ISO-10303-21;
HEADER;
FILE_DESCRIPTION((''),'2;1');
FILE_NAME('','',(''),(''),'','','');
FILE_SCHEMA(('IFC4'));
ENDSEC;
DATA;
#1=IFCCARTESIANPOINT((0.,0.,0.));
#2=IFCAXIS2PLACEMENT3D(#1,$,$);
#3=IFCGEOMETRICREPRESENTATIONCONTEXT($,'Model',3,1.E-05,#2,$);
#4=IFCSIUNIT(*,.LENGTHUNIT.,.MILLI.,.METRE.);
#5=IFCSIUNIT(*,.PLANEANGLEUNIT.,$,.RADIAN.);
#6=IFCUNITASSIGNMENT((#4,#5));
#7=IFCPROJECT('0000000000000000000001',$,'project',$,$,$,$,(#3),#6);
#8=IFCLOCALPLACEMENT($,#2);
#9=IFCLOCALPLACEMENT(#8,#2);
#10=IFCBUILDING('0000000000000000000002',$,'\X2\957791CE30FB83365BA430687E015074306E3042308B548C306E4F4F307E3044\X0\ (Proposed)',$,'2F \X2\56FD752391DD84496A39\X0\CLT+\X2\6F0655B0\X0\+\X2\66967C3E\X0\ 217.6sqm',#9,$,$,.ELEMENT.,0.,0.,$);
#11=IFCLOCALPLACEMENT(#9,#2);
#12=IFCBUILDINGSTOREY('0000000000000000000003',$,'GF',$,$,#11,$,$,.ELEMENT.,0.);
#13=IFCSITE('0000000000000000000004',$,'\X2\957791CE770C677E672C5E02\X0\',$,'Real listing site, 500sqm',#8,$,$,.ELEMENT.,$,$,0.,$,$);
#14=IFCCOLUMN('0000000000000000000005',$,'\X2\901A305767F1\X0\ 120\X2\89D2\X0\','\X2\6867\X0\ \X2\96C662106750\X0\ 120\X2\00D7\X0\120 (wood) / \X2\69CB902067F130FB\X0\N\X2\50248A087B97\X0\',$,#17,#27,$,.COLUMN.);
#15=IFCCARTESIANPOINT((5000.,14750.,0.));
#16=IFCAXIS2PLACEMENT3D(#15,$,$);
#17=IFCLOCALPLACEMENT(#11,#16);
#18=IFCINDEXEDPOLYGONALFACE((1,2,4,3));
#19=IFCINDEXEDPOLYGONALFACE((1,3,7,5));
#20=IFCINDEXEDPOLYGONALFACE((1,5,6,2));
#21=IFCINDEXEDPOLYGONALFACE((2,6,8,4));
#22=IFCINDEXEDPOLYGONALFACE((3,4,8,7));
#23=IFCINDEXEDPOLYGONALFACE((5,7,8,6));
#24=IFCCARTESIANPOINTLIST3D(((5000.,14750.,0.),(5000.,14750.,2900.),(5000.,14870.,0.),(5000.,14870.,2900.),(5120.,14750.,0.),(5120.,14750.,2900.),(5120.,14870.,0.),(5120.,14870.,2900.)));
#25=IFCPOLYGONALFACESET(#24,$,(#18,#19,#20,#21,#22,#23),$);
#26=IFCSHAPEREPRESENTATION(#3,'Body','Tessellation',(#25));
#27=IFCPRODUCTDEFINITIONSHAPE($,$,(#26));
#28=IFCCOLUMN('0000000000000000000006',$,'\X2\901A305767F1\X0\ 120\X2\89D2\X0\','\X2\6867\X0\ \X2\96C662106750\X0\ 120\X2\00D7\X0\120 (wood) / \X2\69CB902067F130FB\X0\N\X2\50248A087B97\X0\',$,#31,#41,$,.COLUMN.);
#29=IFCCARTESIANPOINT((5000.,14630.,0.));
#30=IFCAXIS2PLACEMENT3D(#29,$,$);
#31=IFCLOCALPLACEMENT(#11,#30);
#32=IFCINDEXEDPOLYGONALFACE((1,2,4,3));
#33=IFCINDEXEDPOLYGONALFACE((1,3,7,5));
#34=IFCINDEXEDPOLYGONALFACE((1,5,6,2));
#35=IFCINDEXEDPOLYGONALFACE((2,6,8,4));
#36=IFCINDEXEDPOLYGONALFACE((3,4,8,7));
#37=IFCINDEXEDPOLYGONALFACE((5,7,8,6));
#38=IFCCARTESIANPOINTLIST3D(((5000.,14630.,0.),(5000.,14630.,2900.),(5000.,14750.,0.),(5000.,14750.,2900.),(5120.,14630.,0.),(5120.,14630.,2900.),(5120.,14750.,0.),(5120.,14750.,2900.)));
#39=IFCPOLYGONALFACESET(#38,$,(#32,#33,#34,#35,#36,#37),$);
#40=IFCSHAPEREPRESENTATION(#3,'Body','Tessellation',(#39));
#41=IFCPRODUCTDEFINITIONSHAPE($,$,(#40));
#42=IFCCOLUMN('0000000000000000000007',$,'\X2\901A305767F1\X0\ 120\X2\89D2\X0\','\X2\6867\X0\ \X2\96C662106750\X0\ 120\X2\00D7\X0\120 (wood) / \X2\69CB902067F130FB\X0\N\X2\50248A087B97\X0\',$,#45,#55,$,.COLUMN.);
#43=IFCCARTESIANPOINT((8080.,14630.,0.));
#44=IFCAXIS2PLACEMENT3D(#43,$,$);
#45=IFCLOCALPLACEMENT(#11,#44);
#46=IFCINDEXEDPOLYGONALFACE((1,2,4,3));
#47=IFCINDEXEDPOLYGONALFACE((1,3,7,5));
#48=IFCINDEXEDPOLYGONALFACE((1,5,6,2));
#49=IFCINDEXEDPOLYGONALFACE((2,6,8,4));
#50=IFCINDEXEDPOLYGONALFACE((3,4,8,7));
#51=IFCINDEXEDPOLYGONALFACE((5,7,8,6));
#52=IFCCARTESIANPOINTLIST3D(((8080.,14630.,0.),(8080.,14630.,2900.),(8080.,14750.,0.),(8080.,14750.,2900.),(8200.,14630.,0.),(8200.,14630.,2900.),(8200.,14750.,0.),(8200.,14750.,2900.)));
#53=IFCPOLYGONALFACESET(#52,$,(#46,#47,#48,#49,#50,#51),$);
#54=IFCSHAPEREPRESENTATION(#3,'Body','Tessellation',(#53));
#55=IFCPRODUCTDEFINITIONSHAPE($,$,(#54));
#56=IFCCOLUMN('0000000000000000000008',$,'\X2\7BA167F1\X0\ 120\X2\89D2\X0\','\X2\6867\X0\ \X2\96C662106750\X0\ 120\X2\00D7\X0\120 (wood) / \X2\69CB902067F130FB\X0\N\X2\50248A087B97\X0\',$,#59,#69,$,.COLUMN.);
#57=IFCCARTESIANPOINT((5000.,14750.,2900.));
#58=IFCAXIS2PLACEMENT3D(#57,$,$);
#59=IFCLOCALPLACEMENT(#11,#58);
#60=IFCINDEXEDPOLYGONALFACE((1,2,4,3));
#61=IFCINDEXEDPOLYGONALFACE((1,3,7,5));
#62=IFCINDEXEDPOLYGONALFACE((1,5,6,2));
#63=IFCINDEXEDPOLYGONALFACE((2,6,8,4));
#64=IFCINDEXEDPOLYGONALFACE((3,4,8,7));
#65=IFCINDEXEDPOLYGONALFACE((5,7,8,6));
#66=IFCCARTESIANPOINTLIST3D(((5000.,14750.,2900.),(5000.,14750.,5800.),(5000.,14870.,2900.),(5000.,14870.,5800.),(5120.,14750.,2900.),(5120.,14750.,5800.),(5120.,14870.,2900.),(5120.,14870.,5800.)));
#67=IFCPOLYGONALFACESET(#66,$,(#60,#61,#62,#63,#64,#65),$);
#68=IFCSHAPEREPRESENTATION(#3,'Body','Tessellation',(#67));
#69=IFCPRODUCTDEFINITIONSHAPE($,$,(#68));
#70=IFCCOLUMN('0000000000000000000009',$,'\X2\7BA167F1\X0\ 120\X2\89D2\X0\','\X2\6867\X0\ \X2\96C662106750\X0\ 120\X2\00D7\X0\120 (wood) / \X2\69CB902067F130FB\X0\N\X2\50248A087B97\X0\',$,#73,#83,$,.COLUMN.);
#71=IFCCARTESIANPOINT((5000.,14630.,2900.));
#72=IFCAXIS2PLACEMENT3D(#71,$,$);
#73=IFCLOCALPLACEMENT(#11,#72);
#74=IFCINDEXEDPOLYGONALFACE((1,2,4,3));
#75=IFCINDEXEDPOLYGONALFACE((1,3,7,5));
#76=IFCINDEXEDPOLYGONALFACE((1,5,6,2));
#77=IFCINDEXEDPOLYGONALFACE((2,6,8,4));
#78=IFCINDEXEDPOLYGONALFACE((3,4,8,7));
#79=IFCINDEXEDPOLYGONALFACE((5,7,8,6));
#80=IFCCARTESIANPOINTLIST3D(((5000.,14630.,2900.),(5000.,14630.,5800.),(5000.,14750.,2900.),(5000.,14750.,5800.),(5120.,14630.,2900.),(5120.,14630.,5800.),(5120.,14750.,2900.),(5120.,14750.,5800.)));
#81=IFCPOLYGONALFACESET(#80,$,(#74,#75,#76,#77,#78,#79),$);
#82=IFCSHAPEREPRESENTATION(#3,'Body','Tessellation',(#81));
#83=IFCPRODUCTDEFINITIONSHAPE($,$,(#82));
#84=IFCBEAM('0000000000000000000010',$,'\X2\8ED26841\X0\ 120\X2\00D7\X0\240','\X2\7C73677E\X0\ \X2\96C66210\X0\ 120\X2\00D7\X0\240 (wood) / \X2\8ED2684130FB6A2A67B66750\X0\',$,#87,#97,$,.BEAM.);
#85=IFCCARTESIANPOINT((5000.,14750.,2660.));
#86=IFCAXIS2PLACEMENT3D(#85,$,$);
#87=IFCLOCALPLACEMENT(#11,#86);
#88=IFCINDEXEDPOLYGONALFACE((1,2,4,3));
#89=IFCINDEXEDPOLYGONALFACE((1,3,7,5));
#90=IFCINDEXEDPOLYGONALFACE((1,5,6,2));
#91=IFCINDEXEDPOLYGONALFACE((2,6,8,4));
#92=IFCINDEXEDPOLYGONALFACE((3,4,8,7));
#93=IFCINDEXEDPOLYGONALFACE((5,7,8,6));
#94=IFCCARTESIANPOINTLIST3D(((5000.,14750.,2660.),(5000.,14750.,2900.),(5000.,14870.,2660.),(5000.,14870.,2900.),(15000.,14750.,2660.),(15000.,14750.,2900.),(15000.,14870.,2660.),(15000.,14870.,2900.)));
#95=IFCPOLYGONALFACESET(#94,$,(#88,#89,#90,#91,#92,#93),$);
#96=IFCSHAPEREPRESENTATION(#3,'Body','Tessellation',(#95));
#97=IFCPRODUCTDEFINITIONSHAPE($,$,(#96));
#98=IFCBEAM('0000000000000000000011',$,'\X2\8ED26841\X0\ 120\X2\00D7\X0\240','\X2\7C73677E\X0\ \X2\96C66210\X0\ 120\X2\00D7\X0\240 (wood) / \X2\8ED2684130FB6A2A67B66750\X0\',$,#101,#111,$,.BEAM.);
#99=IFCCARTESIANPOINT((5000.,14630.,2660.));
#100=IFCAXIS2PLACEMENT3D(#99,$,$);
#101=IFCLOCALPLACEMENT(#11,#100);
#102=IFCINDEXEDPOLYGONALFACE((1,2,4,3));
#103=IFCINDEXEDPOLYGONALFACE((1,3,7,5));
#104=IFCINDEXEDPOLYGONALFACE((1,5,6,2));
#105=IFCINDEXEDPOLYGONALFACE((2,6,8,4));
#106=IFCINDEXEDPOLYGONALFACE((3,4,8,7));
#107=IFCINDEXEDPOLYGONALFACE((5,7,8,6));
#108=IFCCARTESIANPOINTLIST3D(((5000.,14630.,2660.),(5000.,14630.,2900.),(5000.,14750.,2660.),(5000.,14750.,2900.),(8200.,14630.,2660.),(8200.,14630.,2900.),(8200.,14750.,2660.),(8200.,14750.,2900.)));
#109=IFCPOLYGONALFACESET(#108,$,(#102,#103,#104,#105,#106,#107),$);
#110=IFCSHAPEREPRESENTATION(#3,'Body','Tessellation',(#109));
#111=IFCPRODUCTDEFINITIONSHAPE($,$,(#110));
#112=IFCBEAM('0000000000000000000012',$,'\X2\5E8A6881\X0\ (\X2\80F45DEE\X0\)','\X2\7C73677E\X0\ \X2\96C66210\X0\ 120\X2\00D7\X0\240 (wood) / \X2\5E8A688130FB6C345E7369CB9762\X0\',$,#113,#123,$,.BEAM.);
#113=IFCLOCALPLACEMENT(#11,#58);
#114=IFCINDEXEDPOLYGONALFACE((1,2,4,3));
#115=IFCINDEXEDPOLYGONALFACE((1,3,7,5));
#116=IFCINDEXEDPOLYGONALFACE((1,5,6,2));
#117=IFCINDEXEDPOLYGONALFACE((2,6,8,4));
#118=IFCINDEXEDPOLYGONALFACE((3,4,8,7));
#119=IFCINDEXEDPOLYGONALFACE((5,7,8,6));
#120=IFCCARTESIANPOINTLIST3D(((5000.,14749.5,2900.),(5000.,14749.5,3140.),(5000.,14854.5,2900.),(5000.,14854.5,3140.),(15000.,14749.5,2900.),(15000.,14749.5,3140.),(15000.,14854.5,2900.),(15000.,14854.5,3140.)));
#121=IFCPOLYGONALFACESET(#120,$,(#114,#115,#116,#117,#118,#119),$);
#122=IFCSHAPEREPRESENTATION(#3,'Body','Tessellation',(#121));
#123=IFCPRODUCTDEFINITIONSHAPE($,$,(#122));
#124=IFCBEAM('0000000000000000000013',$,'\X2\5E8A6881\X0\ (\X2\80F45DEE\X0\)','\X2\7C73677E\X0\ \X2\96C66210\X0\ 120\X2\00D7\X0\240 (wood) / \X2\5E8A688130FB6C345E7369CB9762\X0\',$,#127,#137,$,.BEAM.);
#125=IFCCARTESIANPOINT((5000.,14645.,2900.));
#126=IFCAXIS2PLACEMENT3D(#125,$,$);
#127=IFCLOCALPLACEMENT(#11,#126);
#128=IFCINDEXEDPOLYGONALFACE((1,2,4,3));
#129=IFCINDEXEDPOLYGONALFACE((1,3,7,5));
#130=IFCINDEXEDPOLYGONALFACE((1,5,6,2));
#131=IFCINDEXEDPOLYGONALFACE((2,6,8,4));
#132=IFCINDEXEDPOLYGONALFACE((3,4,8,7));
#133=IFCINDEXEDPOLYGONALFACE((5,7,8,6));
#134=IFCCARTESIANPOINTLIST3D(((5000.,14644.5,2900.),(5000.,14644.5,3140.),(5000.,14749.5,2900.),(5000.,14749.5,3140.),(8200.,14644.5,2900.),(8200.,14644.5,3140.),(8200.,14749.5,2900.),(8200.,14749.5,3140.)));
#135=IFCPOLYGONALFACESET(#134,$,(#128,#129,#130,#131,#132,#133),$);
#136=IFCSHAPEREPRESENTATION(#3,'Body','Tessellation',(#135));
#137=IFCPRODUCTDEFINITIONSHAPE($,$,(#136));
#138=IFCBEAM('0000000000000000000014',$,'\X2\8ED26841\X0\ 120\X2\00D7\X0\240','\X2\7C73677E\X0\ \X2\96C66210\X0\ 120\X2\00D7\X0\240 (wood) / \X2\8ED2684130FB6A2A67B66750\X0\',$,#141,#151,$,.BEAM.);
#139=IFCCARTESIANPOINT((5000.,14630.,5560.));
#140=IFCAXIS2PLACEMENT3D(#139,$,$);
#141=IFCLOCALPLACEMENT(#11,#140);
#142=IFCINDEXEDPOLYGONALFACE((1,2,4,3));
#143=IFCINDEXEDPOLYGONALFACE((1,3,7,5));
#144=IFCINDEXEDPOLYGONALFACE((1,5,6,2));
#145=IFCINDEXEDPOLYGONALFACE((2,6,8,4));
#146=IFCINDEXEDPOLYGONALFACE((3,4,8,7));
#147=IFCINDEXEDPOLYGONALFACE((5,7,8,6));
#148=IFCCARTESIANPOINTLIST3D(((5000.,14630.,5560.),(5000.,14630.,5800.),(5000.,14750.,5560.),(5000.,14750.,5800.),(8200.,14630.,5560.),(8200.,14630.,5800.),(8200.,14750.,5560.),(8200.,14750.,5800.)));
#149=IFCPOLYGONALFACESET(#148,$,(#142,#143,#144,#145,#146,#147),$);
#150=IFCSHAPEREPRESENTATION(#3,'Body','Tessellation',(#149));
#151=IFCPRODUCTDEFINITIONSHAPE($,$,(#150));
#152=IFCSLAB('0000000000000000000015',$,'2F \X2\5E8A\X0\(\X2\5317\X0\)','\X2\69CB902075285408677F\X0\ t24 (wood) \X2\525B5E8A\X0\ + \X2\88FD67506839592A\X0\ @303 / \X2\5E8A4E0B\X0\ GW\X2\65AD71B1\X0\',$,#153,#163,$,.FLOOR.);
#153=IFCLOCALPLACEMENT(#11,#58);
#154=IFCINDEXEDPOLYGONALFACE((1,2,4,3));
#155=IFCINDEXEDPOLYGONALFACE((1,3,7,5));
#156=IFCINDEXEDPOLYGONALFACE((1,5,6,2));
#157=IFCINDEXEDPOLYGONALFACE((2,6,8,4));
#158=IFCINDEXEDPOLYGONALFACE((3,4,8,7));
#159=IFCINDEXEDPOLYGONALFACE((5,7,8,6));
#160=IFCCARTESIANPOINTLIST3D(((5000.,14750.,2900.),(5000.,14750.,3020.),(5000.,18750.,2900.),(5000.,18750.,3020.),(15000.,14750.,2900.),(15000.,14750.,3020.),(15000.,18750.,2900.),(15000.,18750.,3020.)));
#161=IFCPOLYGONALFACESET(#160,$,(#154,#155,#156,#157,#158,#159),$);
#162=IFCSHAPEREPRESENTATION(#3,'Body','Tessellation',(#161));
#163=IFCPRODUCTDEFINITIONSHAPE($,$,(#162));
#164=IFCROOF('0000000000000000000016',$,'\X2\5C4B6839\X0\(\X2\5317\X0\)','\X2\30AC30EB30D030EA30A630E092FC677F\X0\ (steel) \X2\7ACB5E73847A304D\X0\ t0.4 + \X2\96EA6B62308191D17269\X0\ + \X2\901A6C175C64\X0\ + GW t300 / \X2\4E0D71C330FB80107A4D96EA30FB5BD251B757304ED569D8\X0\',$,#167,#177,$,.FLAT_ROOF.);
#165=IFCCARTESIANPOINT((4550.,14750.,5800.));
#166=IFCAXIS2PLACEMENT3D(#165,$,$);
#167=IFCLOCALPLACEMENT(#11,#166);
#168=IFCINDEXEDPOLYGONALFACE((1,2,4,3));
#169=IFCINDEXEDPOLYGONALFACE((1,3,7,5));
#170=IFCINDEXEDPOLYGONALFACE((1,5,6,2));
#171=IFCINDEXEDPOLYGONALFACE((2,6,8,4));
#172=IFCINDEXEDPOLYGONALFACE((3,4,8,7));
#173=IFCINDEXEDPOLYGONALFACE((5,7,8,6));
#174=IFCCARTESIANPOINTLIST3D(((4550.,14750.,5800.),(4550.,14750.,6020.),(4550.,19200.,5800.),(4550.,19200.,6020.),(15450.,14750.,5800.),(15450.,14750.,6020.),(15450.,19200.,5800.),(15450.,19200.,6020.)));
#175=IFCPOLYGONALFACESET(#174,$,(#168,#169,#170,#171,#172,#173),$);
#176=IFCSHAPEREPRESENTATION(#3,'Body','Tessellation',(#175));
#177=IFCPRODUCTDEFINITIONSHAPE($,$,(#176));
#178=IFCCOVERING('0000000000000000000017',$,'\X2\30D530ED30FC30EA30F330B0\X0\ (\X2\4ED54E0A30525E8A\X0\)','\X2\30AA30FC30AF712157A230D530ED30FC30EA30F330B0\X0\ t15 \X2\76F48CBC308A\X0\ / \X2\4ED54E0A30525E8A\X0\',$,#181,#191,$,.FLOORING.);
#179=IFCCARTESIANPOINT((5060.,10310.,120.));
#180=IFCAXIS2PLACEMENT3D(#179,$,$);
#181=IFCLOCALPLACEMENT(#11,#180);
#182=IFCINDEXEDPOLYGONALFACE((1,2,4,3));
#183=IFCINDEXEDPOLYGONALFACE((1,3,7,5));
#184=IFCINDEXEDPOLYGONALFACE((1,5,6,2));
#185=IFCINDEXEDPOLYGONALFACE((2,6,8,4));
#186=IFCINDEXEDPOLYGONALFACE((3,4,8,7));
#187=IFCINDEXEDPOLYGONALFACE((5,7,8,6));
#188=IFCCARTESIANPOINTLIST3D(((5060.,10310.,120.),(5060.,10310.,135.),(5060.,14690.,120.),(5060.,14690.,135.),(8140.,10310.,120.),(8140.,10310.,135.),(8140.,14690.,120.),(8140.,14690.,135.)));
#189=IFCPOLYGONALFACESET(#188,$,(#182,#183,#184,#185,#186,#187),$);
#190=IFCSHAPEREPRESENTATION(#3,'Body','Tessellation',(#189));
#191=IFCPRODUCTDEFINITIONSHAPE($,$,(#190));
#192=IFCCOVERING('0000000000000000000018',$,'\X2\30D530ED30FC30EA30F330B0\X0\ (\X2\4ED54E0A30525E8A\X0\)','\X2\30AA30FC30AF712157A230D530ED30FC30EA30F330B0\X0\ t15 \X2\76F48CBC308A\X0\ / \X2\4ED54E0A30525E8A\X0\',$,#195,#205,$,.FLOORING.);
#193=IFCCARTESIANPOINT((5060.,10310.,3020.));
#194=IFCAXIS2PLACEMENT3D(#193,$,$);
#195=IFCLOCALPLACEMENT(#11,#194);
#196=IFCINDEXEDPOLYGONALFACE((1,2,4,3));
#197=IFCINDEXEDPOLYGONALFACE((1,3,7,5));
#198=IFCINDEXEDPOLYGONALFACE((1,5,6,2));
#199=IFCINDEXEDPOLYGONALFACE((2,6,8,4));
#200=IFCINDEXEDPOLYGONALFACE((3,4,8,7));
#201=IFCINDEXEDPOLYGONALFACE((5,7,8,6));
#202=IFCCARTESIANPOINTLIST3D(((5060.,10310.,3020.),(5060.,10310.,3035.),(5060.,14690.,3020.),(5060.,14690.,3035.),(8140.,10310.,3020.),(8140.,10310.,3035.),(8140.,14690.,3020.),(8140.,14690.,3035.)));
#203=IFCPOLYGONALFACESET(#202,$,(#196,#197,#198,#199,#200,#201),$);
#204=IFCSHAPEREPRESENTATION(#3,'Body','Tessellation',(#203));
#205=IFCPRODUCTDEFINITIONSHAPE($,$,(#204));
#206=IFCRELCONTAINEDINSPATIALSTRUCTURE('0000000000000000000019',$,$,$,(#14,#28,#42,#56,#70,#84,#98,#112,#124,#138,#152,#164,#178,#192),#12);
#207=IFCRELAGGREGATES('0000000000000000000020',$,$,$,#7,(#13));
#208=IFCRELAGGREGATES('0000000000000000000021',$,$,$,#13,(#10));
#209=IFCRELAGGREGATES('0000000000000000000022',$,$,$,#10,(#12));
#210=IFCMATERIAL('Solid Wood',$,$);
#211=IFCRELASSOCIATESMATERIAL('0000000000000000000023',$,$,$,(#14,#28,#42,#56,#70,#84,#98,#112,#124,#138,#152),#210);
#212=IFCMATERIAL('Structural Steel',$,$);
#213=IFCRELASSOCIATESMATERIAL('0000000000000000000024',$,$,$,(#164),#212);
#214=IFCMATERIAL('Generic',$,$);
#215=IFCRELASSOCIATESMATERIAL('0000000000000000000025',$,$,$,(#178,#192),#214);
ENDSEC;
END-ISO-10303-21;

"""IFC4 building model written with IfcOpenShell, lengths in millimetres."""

from ifc_helpers import new_model, si_unit, frame, frame_2d, origin, place, context, project, spatial, rectangle, extrude, material, element, save


model = new_model("IFC4")

# Units and contexts
model_context = context("Model", 3, precision=1e-05, world=origin())
ifc_project = project(units=[si_unit("LENGTHUNIT", "METRE", prefix="MILLI"), si_unit("PLANEANGLEUNIT", "RADIAN")], contexts=[model_context])

# Site, building, storey
site_placement = place(None, origin())
site = spatial("IfcSite", under=ifc_project, at=site_placement, Name="長野県松本市", ObjectType="Real listing site, 500sqm", CompositionType="ELEMENT", RefElevation=0.0)
building_placement = place(site_placement, origin())
building = spatial("IfcBuilding", under=site, at=building_placement, Name="長野・茶室と縁側のある和の住まい (Proposed)", ObjectType="2F 国産針葉樹CLT+漆喰+暖簾 217.6sqm", CompositionType="ELEMENT", ElevationOfRefHeight=0.0, ElevationOfTerrain=0.0)
storey_placement = place(building_placement, origin())
storey = spatial("IfcBuildingStorey", under=building, at=storey_placement, Name="GF", CompositionType="ELEMENT", Elevation=0.0)

# Columns
ifc_material_1 = material(Name="Solid Wood")
column_1_placement = place(storey_placement, frame((5000.0, 14750.0, 0.0)))
element("IfcColumn", 1, at=column_1_placement, inside=storey, material=ifc_material_1, Name="通し柱 120角", Description="桧 集成材 120×120 (wood) / 構造柱・N値計算", PredefinedType="COLUMN", context=model_context, shape_type="SweptSolid", body=[
    extrude(rectangle(XDim=120.0, YDim=120.0, at=frame_2d((60.0, 60.0))), frame((5000.0, 14750.0, 0.0)), (0.0, 0.0, 1.0), 2900.0),
])
column_2_placement = place(storey_placement, frame((5000.0, 14630.0, 0.0)))
element("IfcColumn", 2, at=column_2_placement, inside=storey, material=ifc_material_1, Name="通し柱 120角", Description="桧 集成材 120×120 (wood) / 構造柱・N値計算", PredefinedType="COLUMN", context=model_context, shape_type="SweptSolid", body=[
    extrude(rectangle(XDim=120.0, YDim=120.0, at=frame_2d((60.0, 60.0))), frame((5000.0, 14630.0, 0.0)), (0.0, 0.0, 1.0), 2900.0),
])
column_3_placement = place(storey_placement, frame((8080.0, 14630.0, 0.0)))
element("IfcColumn", 3, at=column_3_placement, inside=storey, material=ifc_material_1, Name="通し柱 120角", Description="桧 集成材 120×120 (wood) / 構造柱・N値計算", PredefinedType="COLUMN", context=model_context, shape_type="SweptSolid", body=[
    extrude(rectangle(XDim=120.0, YDim=120.0, at=frame_2d((60.0, 60.0))), frame((8080.0, 14630.0, 0.0)), (0.0, 0.0, 1.0), 2900.0),
])
column_4_placement = place(storey_placement, frame((5000.0, 14750.0, 2900.0)))
element("IfcColumn", 4, at=column_4_placement, inside=storey, material=ifc_material_1, Name="管柱 120角", Description="桧 集成材 120×120 (wood) / 構造柱・N値計算", PredefinedType="COLUMN", context=model_context, shape_type="SweptSolid", body=[
    extrude(rectangle(XDim=120.0, YDim=120.0, at=frame_2d((60.0, 60.0))), frame((5000.0, 14750.0, 2900.0)), (0.0, 0.0, 1.0), 2900.0),
])
column_5_placement = place(storey_placement, frame((5000.0, 14630.0, 2900.0)))
element("IfcColumn", 5, at=column_5_placement, inside=storey, material=ifc_material_1, Name="管柱 120角", Description="桧 集成材 120×120 (wood) / 構造柱・N値計算", PredefinedType="COLUMN", context=model_context, shape_type="SweptSolid", body=[
    extrude(rectangle(XDim=120.0, YDim=120.0, at=frame_2d((60.0, 60.0))), frame((5000.0, 14630.0, 2900.0)), (0.0, 0.0, 1.0), 2900.0),
])

# Beams
beam_1_placement = place(storey_placement, frame((5000.0, 14750.0, 2660.0)))
element("IfcBeam", 6, at=beam_1_placement, inside=storey, material=ifc_material_1, Name="軒桁 120×240", Description="米松 集成 120×240 (wood) / 軒桁・横架材", PredefinedType="BEAM", context=model_context, shape_type="SweptSolid", body=[
    extrude(rectangle(XDim=10000.0, YDim=120.0, at=frame_2d((5000.0, 60.0))), frame((5000.0, 14750.0, 2660.0)), (0.0, 0.0, 1.0), 240.0),
])
beam_2_placement = place(storey_placement, frame((5000.0, 14630.0, 2660.0)))
element("IfcBeam", 7, at=beam_2_placement, inside=storey, material=ifc_material_1, Name="軒桁 120×240", Description="米松 集成 120×240 (wood) / 軒桁・横架材", PredefinedType="BEAM", context=model_context, shape_type="SweptSolid", body=[
    extrude(rectangle(XDim=3200.0, YDim=120.0, at=frame_2d((1600.0, 60.0))), frame((5000.0, 14630.0, 2660.0)), (0.0, 0.0, 1.0), 240.0),
])
beam_3_placement = place(storey_placement, frame((5000.0, 14750.0, 2900.0)))
element("IfcBeam", 8, at=beam_3_placement, inside=storey, material=ifc_material_1, Name="床梁 (胴差)", Description="米松 集成 120×240 (wood) / 床梁・水平構面", PredefinedType="BEAM", context=model_context, shape_type="SweptSolid", body=[
    extrude(rectangle(XDim=10000.0, YDim=105.0, at=frame_2d((5000.0, 52.0))), frame((5000.0, 14750.0, 2900.0)), (0.0, 0.0, 1.0), 240.0),
])
beam_4_placement = place(storey_placement, frame((5000.0, 14645.0, 2900.0)))
element("IfcBeam", 9, at=beam_4_placement, inside=storey, material=ifc_material_1, Name="床梁 (胴差)", Description="米松 集成 120×240 (wood) / 床梁・水平構面", PredefinedType="BEAM", context=model_context, shape_type="SweptSolid", body=[
    extrude(rectangle(XDim=3200.0, YDim=105.0, at=frame_2d((1600.0, 52.0))), frame((5000.0, 14645.0, 2900.0)), (0.0, 0.0, 1.0), 240.0),
])
beam_5_placement = place(storey_placement, frame((5000.0, 14630.0, 5560.0)))
element("IfcBeam", 10, at=beam_5_placement, inside=storey, material=ifc_material_1, Name="軒桁 120×240", Description="米松 集成 120×240 (wood) / 軒桁・横架材", PredefinedType="BEAM", context=model_context, shape_type="SweptSolid", body=[
    extrude(rectangle(XDim=3200.0, YDim=120.0, at=frame_2d((1600.0, 60.0))), frame((5000.0, 14630.0, 5560.0)), (0.0, 0.0, 1.0), 240.0),
])

# Slab
slab_1_placement = place(storey_placement, frame((5000.0, 14750.0, 2900.0)))
element("IfcSlab", 11, at=slab_1_placement, inside=storey, material=ifc_material_1, Name="2F 床(北)", Description="構造用合板 t24 (wood) 剛床 + 製材根太 @303 / 床下 GW断熱", PredefinedType="FLOOR", context=model_context, shape_type="SweptSolid", body=[
    extrude(rectangle(XDim=10000.0, YDim=4000.0, at=frame_2d((5000.0, 2000.0))), frame((5000.0, 14750.0, 2900.0)), (0.0, 0.0, 1.0), 120.0),
])

# Roof
ifc_material_2 = material(Name="Structural Steel")
for number, where, name in (
    (12, (4550.0, 14750.0, 5800.0), "屋根(北)"),
):
    element("IfcRoof", number, at=place(storey_placement, frame(where)), inside=storey, material=ifc_material_2, Name=name, Description="ガルバリウム鋼板 (steel) 立平葺き t0.4 + 雪止め金物 + 通気層 + GW t300 / 不燃・耐積雪・寒冷地仕様", PredefinedType="FLAT_ROOF", context=model_context, shape_type="SweptSolid", body=[
        extrude(rectangle(XDim=10900.0, YDim=4450.0, at=frame_2d((5450.0, 2225.0))), frame((4550.0, 14750.0, 5800.0)), (0.0, 0.0, 1.0), 220.0),
    ])

# Coverings
ifc_material_3 = material(Name="Generic")
covering_1_placement = place(storey_placement, frame((5060.0, 10310.0, 120.0)))
element("IfcCovering", 13, at=covering_1_placement, inside=storey, material=ifc_material_3, Name="フローリング (仕上げ床)", Description="オーク無垢フローリング t15 直貼り / 仕上げ床", PredefinedType="FLOORING", context=model_context, shape_type="SweptSolid", body=[
    extrude(rectangle(XDim=3080.0, YDim=4380.0, at=frame_2d((1540.0, 2190.0))), frame((5060.0, 10310.0, 120.0)), (0.0, 0.0, 1.0), 15.0),
])
covering_2_placement = place(storey_placement, frame((5060.0, 10310.0, 3020.0)))
element("IfcCovering", 14, at=covering_2_placement, inside=storey, material=ifc_material_3, Name="フローリング (仕上げ床)", Description="オーク無垢フローリング t15 直貼り / 仕上げ床", PredefinedType="FLOORING", context=model_context, shape_type="SweptSolid", body=[
    extrude(rectangle(XDim=3080.0, YDim=4380.0, at=frame_2d((1540.0, 2190.0))), frame((5060.0, 10310.0, 3020.0)), (0.0, 0.0, 1.0), 15.0),
])

save(model, "model.ifc")
